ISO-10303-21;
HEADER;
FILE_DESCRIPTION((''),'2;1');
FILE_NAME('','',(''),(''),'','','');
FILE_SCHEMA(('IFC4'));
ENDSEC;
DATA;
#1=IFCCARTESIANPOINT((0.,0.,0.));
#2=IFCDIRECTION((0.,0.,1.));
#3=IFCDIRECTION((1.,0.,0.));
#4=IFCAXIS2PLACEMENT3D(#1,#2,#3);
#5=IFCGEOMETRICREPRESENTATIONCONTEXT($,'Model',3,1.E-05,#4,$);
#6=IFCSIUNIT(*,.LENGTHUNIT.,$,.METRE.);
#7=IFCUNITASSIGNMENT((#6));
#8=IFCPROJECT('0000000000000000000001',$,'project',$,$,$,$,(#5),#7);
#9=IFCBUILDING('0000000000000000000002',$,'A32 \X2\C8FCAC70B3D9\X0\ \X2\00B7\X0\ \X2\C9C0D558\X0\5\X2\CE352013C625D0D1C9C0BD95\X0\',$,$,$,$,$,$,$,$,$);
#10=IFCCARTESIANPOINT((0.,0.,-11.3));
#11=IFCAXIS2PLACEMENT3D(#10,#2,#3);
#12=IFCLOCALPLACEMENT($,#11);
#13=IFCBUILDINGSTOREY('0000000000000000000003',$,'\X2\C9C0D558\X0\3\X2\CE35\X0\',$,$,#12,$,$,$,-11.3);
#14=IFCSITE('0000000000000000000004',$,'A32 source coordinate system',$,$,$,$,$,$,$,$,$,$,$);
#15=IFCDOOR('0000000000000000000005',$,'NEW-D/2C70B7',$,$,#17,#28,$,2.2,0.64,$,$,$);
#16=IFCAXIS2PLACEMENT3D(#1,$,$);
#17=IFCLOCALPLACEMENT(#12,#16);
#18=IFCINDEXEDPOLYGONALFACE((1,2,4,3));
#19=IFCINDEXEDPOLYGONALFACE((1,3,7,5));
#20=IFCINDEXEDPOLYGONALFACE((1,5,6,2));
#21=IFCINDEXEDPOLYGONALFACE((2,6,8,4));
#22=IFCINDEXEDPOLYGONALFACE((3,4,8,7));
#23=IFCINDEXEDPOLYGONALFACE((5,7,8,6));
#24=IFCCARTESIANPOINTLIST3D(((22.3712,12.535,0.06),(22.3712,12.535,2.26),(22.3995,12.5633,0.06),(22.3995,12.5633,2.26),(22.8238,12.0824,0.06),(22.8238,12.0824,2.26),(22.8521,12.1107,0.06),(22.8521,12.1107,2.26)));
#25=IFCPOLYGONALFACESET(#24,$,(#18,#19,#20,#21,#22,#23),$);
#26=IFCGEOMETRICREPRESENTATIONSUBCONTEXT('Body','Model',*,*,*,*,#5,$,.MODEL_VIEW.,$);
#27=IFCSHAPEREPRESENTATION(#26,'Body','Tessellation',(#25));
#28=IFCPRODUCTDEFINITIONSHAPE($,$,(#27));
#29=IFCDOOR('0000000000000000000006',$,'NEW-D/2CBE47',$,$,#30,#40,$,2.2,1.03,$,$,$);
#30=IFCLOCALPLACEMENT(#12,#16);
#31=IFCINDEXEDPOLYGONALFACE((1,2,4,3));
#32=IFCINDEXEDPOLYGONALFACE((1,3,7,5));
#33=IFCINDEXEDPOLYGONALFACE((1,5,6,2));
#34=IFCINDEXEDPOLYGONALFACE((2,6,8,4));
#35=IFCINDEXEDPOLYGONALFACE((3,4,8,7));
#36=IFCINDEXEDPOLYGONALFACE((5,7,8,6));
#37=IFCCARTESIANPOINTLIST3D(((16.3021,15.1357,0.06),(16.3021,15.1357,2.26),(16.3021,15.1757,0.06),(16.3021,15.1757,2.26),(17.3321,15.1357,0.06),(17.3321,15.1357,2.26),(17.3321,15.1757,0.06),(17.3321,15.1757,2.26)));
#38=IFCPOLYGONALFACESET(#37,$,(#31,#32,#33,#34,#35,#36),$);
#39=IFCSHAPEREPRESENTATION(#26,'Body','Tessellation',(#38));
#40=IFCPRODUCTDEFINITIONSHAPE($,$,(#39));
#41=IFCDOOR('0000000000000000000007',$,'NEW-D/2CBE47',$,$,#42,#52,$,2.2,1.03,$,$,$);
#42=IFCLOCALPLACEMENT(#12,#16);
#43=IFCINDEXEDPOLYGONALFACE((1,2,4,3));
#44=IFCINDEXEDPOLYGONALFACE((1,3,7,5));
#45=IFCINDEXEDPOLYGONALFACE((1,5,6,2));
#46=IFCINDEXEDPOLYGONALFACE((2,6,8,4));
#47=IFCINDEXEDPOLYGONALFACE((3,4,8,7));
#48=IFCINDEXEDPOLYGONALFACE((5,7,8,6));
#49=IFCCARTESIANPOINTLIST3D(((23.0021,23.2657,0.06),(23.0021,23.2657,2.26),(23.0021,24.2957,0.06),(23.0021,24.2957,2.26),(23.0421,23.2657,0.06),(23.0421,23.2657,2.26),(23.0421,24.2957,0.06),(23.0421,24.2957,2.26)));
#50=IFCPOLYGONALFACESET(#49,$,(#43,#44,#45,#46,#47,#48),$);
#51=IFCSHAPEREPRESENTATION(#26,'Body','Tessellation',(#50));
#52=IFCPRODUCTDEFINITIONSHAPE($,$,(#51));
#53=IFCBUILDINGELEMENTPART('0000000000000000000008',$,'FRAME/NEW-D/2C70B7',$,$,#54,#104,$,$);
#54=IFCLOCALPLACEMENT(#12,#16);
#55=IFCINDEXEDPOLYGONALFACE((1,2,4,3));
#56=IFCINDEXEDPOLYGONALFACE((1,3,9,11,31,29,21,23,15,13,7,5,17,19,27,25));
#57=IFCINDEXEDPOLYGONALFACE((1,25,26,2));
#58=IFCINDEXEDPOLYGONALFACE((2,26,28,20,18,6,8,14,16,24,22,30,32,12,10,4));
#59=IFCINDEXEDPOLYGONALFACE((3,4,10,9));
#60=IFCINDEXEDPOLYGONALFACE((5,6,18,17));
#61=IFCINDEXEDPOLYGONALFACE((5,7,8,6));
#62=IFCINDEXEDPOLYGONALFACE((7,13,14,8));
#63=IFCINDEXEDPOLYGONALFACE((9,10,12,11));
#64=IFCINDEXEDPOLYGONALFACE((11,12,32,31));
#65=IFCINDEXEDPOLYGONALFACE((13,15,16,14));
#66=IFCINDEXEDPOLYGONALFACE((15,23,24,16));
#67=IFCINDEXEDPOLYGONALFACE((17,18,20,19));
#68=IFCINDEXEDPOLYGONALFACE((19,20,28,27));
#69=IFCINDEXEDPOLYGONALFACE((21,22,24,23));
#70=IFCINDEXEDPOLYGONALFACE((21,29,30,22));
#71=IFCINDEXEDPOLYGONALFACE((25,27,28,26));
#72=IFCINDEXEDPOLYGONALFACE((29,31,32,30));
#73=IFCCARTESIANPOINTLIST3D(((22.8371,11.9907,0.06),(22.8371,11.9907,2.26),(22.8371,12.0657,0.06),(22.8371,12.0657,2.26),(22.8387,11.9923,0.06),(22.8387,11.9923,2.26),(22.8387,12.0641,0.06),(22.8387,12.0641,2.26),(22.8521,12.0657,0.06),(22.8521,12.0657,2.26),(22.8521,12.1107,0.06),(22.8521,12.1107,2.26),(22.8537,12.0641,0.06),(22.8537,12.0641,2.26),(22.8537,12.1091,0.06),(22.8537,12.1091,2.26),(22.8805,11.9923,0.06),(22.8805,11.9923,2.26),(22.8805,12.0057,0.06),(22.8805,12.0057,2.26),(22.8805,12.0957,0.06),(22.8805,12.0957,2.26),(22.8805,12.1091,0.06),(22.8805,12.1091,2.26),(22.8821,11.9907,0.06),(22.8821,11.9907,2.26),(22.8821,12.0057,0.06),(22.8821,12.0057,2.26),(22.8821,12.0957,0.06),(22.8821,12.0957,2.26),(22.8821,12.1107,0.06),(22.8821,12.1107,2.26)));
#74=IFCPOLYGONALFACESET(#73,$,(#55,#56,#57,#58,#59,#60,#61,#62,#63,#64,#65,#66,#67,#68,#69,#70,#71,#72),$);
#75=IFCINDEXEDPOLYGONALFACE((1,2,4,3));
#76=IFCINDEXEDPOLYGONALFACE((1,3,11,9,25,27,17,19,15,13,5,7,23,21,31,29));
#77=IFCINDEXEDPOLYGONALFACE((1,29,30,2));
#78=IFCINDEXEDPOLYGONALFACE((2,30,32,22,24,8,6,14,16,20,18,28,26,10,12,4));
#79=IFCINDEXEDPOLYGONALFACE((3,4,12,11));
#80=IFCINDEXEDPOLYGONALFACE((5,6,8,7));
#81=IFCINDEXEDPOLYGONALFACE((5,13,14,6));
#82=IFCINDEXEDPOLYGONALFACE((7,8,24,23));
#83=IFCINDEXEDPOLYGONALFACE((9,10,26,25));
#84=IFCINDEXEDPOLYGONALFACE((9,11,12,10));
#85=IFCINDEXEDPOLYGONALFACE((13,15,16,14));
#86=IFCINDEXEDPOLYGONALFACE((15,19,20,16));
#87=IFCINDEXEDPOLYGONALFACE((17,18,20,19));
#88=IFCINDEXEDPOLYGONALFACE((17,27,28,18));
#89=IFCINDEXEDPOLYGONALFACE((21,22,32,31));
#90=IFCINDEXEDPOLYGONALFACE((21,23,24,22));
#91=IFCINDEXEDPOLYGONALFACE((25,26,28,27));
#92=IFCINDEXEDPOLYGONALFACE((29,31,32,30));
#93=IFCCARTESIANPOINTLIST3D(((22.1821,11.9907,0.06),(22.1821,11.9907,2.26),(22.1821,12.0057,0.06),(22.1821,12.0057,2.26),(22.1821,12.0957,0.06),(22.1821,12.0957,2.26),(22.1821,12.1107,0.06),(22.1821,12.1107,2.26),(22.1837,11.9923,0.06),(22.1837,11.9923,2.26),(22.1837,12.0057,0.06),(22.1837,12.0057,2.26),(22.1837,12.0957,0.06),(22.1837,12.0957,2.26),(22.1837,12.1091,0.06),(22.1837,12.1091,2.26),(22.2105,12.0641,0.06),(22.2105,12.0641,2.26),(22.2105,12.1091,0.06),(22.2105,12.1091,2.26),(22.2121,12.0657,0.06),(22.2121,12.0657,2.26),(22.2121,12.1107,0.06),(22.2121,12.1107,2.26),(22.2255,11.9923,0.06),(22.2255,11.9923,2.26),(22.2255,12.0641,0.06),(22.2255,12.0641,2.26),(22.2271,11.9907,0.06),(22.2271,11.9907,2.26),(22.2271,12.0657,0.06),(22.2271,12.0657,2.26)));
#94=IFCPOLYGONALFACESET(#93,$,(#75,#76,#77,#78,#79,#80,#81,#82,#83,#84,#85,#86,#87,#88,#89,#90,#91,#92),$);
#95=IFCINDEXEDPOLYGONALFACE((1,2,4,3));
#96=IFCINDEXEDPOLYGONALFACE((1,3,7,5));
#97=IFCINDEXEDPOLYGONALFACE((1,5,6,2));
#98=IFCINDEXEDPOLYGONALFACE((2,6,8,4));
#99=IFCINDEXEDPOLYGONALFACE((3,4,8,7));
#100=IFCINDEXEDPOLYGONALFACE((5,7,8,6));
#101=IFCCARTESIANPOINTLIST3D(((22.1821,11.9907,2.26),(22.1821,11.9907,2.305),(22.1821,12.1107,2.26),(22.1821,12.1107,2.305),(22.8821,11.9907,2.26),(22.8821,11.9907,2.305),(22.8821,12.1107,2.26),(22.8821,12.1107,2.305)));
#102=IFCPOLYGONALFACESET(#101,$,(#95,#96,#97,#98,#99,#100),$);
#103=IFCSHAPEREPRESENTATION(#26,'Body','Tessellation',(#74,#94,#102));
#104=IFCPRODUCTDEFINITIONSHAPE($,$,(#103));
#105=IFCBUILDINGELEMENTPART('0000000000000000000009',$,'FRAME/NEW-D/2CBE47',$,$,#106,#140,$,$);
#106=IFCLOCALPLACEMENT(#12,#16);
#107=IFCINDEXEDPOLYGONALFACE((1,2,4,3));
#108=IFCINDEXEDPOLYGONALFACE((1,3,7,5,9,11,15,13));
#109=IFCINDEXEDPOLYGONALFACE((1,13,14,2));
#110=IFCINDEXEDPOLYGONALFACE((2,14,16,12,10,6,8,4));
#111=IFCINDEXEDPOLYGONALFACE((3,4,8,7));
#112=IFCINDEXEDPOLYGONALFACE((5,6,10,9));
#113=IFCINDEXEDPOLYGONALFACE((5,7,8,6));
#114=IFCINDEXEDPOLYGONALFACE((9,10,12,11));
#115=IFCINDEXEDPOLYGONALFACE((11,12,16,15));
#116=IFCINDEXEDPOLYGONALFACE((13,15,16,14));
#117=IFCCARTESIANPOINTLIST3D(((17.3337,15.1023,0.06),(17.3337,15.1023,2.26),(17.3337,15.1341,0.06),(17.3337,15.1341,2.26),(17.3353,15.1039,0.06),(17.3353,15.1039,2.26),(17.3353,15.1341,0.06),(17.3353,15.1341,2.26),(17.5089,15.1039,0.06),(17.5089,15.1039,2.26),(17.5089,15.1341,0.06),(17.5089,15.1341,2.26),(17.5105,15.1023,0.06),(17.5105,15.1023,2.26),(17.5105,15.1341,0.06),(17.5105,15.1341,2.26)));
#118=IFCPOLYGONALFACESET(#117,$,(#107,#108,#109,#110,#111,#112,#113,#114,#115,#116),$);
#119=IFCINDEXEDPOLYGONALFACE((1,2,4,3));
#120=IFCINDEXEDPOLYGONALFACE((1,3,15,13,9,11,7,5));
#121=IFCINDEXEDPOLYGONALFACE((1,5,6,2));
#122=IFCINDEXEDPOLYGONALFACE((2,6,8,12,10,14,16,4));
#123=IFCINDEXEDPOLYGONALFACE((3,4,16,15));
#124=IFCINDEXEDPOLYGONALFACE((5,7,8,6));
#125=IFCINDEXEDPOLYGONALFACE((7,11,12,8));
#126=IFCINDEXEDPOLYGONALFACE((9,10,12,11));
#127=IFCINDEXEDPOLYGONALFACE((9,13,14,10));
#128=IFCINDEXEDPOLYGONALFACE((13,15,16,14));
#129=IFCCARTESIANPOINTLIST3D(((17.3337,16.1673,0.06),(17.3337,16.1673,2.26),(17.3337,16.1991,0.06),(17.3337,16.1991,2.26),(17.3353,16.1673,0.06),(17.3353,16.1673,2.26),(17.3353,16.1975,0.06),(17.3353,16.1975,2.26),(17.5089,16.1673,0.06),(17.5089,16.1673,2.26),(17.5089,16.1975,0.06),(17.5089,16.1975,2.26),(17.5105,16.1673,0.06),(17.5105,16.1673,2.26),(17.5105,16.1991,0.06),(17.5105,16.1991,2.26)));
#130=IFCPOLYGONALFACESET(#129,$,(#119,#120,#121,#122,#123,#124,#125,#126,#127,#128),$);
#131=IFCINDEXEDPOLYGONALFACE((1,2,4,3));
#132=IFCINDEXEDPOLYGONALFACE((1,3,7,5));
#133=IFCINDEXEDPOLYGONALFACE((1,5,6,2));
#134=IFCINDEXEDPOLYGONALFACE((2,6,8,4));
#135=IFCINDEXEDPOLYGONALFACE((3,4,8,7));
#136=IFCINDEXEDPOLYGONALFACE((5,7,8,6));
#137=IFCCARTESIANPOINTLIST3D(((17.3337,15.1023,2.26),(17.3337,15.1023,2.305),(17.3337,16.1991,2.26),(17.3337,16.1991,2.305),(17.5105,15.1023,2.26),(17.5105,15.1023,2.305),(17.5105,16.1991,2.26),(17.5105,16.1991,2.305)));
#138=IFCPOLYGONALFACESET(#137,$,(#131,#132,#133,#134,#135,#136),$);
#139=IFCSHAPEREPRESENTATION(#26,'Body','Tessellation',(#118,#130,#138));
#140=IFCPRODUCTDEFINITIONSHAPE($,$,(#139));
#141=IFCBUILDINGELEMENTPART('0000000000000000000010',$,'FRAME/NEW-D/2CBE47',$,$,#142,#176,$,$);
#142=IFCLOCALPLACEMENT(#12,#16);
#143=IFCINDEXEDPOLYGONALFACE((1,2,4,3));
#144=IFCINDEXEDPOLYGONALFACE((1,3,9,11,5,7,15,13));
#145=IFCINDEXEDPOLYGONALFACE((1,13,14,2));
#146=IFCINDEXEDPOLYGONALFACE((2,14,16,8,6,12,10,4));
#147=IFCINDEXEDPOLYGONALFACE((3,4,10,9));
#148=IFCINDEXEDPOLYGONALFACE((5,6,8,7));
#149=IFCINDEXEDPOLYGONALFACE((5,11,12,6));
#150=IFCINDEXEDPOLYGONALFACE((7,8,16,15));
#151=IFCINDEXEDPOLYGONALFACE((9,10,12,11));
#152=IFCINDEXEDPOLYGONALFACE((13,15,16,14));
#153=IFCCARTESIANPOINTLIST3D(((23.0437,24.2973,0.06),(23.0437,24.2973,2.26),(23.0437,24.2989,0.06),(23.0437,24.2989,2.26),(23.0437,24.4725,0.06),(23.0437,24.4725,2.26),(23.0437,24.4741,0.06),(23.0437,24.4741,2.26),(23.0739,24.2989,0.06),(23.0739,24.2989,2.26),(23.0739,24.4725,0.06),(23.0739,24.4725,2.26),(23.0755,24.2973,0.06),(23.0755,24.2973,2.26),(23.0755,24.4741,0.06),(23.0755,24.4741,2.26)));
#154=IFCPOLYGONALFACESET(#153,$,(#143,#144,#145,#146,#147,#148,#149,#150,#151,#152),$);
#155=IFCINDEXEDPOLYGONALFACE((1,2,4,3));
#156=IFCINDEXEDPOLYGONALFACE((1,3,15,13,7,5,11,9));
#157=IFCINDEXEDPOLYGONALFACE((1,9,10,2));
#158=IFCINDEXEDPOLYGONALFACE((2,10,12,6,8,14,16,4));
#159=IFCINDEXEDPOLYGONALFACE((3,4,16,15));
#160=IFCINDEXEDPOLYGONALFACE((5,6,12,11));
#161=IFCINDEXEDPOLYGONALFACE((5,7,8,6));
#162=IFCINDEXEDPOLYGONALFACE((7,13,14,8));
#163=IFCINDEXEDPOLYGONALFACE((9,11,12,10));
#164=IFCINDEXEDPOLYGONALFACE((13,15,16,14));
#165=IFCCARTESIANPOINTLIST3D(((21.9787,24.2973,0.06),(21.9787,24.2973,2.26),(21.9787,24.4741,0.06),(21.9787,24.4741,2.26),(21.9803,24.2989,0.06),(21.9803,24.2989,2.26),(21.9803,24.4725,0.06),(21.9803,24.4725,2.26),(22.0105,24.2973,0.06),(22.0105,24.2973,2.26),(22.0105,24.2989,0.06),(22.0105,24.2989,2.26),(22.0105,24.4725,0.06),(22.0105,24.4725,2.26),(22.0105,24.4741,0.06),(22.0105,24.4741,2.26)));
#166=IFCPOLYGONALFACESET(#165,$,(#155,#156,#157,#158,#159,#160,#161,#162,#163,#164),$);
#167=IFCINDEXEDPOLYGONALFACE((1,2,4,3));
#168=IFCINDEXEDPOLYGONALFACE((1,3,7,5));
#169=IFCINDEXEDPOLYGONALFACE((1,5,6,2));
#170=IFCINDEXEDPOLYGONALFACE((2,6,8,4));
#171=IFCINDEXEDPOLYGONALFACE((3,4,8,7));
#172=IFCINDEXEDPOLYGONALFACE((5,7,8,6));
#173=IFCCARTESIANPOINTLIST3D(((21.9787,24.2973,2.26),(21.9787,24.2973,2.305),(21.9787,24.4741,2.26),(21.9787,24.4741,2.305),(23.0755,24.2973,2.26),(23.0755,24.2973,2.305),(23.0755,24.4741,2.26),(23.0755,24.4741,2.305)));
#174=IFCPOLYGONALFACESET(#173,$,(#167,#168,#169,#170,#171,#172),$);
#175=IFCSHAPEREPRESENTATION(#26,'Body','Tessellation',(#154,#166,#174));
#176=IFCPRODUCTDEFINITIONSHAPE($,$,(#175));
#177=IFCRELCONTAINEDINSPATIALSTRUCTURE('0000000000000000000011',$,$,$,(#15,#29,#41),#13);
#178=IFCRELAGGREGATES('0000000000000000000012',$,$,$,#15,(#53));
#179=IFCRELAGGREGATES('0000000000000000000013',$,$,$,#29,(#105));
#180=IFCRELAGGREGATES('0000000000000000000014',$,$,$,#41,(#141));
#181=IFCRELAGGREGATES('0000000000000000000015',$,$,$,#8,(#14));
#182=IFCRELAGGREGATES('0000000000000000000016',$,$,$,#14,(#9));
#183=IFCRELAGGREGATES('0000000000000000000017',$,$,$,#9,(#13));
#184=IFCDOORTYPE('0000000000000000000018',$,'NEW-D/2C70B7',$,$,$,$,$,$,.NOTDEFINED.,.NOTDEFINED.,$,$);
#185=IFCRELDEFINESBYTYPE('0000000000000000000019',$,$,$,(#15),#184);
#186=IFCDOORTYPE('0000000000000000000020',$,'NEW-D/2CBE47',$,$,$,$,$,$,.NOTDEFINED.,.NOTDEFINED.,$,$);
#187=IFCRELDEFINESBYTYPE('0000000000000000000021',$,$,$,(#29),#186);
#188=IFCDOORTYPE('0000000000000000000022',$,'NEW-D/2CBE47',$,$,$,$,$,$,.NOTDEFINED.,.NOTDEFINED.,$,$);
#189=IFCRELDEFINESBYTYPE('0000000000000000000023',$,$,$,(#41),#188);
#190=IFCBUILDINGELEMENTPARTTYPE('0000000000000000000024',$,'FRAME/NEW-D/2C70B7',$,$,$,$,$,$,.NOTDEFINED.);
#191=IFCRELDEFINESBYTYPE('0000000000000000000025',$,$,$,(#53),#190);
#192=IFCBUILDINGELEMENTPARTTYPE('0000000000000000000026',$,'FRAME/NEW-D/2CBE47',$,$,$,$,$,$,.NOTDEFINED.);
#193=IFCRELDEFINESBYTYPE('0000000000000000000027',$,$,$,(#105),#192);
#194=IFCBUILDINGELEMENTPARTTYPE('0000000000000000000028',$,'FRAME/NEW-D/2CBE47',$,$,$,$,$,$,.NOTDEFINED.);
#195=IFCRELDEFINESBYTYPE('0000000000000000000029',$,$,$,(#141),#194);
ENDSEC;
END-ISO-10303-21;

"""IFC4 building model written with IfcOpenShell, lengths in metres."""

from ifc_helpers import new_model, si_unit, frame, origin, origin_with_axes, place, context, subcontext, project, spatial, polyline, outline, extrude, source, transform, mapped, type_object, type_shapes, element, aggregate, save


model = new_model("IFC4")

# Units and contexts
model_context = context("Model", 3, precision=1e-05, world=origin_with_axes())
body_context = subcontext(model_context, "Body", "Model", "MODEL_VIEW")
ifc_project = project(units=[si_unit("LENGTHUNIT", "METRE")], contexts=[model_context])

# Site, building, storey
site = spatial("IfcSite", under=ifc_project, Name="A32 source coordinate system")
building = spatial("IfcBuilding", under=site, Name="A32 주거동 · 지하5층–옥탑지붕")
storey_placement = place(None, frame((0.0, 0.0, -11.3), z_axis=(0.0, 0.0, 1.0), x_axis=(1.0, 0.0, 0.0)))
storey = spatial("IfcBuildingStorey", under=building, at=storey_placement, Name="지하3층", Elevation=-11.3)

# Doors
door_type_1 = type_object("IfcDoorType", Name="NEW-D/2C70B7", OperationType="NOTDEFINED", PredefinedType="NOTDEFINED")
shared_shape_1 = source(origin(), body_context, "Body", "SweptSolid", [
    extrude(outline(polyline([(22.8521, 12.1107), (22.8238, 12.0824), (22.3712, 12.535), (22.3995, 12.5633), (22.8521, 12.1107)])), frame((0.0, 0.0, 0.06)), (0.0, 0.0, 1.0), 2.2),
])
type_shapes(door_type_1, [shared_shape_1])
door_1_placement = place(storey_placement, origin_with_axes())
door_1 = element("IfcDoor", 1, at=door_1_placement, inside=storey, type_object=door_type_1, Name="NEW-D/2C70B7", OverallHeight=2.2, OverallWidth=0.64, context=body_context, shape_type="MappedRepresentation", body=[
    mapped(shared_shape_1, transform((0.0, 0.0, 0.0), scale=1.0)),
])
door_type_2 = type_object("IfcDoorType", Name="NEW-D/2CBE47", OperationType="NOTDEFINED", PredefinedType="NOTDEFINED")
shared_shape_2 = source(origin(), body_context, "Body", "SweptSolid", [
    extrude(outline(polyline([(16.3021, 15.1757), (17.3321, 15.1757), (17.3321, 15.1357), (16.3021, 15.1357), (16.3021, 15.1757)])), frame((0.0, 0.0, 0.06)), (0.0, 0.0, 1.0), 2.2),
])
type_shapes(door_type_2, [shared_shape_2])
door_2_placement = place(storey_placement, origin_with_axes())
door_2 = element("IfcDoor", 2, at=door_2_placement, inside=storey, type_object=door_type_2, Name="NEW-D/2CBE47", OverallHeight=2.2, OverallWidth=1.03, context=body_context, shape_type="MappedRepresentation", body=[
    mapped(shared_shape_2, transform((0.0, 0.0, 0.0), scale=1.0)),
])
door_type_3 = type_object("IfcDoorType", Name="NEW-D/2CBE47", OperationType="NOTDEFINED", PredefinedType="NOTDEFINED")
shared_shape_3 = source(origin(), body_context, "Body", "SweptSolid", [
    extrude(outline(polyline([(23.0021, 23.2657), (23.0021, 24.2957), (23.0421, 24.2957), (23.0421, 23.2657), (23.0021, 23.2657)])), frame((0.0, 0.0, 0.06)), (0.0, 0.0, 1.0), 2.2),
])
type_shapes(door_type_3, [shared_shape_3])
door_3_placement = place(storey_placement, origin_with_axes())
door_3 = element("IfcDoor", 3, at=door_3_placement, inside=storey, type_object=door_type_3, Name="NEW-D/2CBE47", OverallHeight=2.2, OverallWidth=1.03, context=body_context, shape_type="MappedRepresentation", body=[
    mapped(shared_shape_3, transform((0.0, 0.0, 0.0), scale=1.0)),
])

# Building element parts
building_element_part_type_1 = type_object("IfcBuildingElementPartType", Name="FRAME/NEW-D/2C70B7", PredefinedType="NOTDEFINED")
shared_shape_4 = source(origin(), body_context, "Body", "SweptSolid", [
    extrude(outline(polyline([(22.8537, 12.1091), (22.8537, 12.0641), (22.8387, 12.0641), (22.8387, 11.9923), (22.8805, 11.9923), (22.8805, 12.0057), (22.8821, 12.0057), (22.8821, 11.9907), (22.8371, 11.9907), (22.8371, 12.0657), (22.8521, 12.0657), (22.8521, 12.1107), (22.8821, 12.1107), (22.8821, 12.0957), (22.8805, 12.0957), (22.8805, 12.1091), (22.8537, 12.1091)])), frame((0.0, 0.0, 0.06)), (0.0, 0.0, 1.0), 2.2),
    extrude(outline(polyline([(22.1821, 12.1107), (22.2121, 12.1107), (22.2121, 12.0657), (22.2271, 12.0657), (22.2271, 11.9907), (22.1821, 11.9907), (22.1821, 12.0057), (22.1837, 12.0057), (22.1837, 11.9923), (22.2255, 11.9923), (22.2255, 12.0641), (22.2105, 12.0641), (22.2105, 12.1091), (22.1837, 12.1091), (22.1837, 12.0957), (22.1821, 12.0957), (22.1821, 12.1107)])), frame((0.0, 0.0, 0.06)), (0.0, 0.0, 1.0), 2.2),
    extrude(outline(polyline([(22.8821, 11.9907), (22.8821, 12.1107), (22.1821, 12.1107), (22.1821, 11.9907), (22.8821, 11.9907)])), frame((0.0, 0.0, 2.26)), (0.0, 0.0, 1.0), 0.045),
])
type_shapes(building_element_part_type_1, [shared_shape_4])
building_element_part_1_placement = place(door_1_placement, origin_with_axes())
building_element_part_1 = element("IfcBuildingElementPart", 4, at=building_element_part_1_placement, type_object=building_element_part_type_1, Name="FRAME/NEW-D/2C70B7", context=body_context, shape_type="MappedRepresentation", body=[
    mapped(shared_shape_4, transform((0.0, 0.0, 0.0), scale=1.0)),
])
aggregate(door_1, [building_element_part_1])
building_element_part_type_2 = type_object("IfcBuildingElementPartType", Name="FRAME/NEW-D/2CBE47", PredefinedType="NOTDEFINED")
shared_shape_5 = source(origin(), body_context, "Body", "SweptSolid", [
    extrude(outline(polyline([(17.3353, 15.1039), (17.5089, 15.1039), (17.5089, 15.1341), (17.5105, 15.1341), (17.5105, 15.1023), (17.3337, 15.1023), (17.3337, 15.1341), (17.3353, 15.1341), (17.3353, 15.1039)])), frame((0.0, 0.0, 0.06)), (0.0, 0.0, 1.0), 2.2),
    extrude(outline(polyline([(17.5105, 16.1991), (17.5105, 16.1673), (17.5089, 16.1673), (17.5089, 16.1975), (17.3353, 16.1975), (17.3353, 16.1673), (17.3337, 16.1673), (17.3337, 16.1991), (17.5105, 16.1991)])), frame((0.0, 0.0, 0.06)), (0.0, 0.0, 1.0), 2.2),
    extrude(outline(polyline([(17.5105, 15.1023), (17.5105, 16.1991), (17.3337, 16.1991), (17.3337, 15.1023), (17.5105, 15.1023)])), frame((0.0, 0.0, 2.26)), (0.0, 0.0, 1.0), 0.045),
])
type_shapes(building_element_part_type_2, [shared_shape_5])
building_element_part_2_placement = place(door_2_placement, origin_with_axes())
building_element_part_2 = element("IfcBuildingElementPart", 5, at=building_element_part_2_placement, type_object=building_element_part_type_2, Name="FRAME/NEW-D/2CBE47", context=body_context, shape_type="MappedRepresentation", body=[
    mapped(shared_shape_5, transform((0.0, 0.0, 0.0), scale=1.0)),
])
aggregate(door_2, [building_element_part_2])
building_element_part_type_3 = type_object("IfcBuildingElementPartType", Name="FRAME/NEW-D/2CBE47", PredefinedType="NOTDEFINED")
shared_shape_6 = source(origin(), body_context, "Body", "SweptSolid", [
    extrude(outline(polyline([(23.0739, 24.2989), (23.0739, 24.4725), (23.0437, 24.4725), (23.0437, 24.4741), (23.0755, 24.4741), (23.0755, 24.2973), (23.0437, 24.2973), (23.0437, 24.2989), (23.0739, 24.2989)])), frame((0.0, 0.0, 0.06)), (0.0, 0.0, 1.0), 2.2),
    extrude(outline(polyline([(21.9787, 24.4741), (22.0105, 24.4741), (22.0105, 24.4725), (21.9803, 24.4725), (21.9803, 24.2989), (22.0105, 24.2989), (22.0105, 24.2973), (21.9787, 24.2973), (21.9787, 24.4741)])), frame((0.0, 0.0, 0.06)), (0.0, 0.0, 1.0), 2.2),
    extrude(outline(polyline([(23.0755, 24.2973), (23.0755, 24.4741), (21.9787, 24.4741), (21.9787, 24.2973), (23.0755, 24.2973)])), frame((0.0, 0.0, 2.26)), (0.0, 0.0, 1.0), 0.045),
])
type_shapes(building_element_part_type_3, [shared_shape_6])
building_element_part_3_placement = place(door_3_placement, origin_with_axes())
building_element_part_3 = element("IfcBuildingElementPart", 6, at=building_element_part_3_placement, type_object=building_element_part_type_3, Name="FRAME/NEW-D/2CBE47", context=body_context, shape_type="MappedRepresentation", body=[
    mapped(shared_shape_6, transform((0.0, 0.0, 0.0), scale=1.0)),
])
aggregate(door_3, [building_element_part_3])

save(model, "model.ifc")
